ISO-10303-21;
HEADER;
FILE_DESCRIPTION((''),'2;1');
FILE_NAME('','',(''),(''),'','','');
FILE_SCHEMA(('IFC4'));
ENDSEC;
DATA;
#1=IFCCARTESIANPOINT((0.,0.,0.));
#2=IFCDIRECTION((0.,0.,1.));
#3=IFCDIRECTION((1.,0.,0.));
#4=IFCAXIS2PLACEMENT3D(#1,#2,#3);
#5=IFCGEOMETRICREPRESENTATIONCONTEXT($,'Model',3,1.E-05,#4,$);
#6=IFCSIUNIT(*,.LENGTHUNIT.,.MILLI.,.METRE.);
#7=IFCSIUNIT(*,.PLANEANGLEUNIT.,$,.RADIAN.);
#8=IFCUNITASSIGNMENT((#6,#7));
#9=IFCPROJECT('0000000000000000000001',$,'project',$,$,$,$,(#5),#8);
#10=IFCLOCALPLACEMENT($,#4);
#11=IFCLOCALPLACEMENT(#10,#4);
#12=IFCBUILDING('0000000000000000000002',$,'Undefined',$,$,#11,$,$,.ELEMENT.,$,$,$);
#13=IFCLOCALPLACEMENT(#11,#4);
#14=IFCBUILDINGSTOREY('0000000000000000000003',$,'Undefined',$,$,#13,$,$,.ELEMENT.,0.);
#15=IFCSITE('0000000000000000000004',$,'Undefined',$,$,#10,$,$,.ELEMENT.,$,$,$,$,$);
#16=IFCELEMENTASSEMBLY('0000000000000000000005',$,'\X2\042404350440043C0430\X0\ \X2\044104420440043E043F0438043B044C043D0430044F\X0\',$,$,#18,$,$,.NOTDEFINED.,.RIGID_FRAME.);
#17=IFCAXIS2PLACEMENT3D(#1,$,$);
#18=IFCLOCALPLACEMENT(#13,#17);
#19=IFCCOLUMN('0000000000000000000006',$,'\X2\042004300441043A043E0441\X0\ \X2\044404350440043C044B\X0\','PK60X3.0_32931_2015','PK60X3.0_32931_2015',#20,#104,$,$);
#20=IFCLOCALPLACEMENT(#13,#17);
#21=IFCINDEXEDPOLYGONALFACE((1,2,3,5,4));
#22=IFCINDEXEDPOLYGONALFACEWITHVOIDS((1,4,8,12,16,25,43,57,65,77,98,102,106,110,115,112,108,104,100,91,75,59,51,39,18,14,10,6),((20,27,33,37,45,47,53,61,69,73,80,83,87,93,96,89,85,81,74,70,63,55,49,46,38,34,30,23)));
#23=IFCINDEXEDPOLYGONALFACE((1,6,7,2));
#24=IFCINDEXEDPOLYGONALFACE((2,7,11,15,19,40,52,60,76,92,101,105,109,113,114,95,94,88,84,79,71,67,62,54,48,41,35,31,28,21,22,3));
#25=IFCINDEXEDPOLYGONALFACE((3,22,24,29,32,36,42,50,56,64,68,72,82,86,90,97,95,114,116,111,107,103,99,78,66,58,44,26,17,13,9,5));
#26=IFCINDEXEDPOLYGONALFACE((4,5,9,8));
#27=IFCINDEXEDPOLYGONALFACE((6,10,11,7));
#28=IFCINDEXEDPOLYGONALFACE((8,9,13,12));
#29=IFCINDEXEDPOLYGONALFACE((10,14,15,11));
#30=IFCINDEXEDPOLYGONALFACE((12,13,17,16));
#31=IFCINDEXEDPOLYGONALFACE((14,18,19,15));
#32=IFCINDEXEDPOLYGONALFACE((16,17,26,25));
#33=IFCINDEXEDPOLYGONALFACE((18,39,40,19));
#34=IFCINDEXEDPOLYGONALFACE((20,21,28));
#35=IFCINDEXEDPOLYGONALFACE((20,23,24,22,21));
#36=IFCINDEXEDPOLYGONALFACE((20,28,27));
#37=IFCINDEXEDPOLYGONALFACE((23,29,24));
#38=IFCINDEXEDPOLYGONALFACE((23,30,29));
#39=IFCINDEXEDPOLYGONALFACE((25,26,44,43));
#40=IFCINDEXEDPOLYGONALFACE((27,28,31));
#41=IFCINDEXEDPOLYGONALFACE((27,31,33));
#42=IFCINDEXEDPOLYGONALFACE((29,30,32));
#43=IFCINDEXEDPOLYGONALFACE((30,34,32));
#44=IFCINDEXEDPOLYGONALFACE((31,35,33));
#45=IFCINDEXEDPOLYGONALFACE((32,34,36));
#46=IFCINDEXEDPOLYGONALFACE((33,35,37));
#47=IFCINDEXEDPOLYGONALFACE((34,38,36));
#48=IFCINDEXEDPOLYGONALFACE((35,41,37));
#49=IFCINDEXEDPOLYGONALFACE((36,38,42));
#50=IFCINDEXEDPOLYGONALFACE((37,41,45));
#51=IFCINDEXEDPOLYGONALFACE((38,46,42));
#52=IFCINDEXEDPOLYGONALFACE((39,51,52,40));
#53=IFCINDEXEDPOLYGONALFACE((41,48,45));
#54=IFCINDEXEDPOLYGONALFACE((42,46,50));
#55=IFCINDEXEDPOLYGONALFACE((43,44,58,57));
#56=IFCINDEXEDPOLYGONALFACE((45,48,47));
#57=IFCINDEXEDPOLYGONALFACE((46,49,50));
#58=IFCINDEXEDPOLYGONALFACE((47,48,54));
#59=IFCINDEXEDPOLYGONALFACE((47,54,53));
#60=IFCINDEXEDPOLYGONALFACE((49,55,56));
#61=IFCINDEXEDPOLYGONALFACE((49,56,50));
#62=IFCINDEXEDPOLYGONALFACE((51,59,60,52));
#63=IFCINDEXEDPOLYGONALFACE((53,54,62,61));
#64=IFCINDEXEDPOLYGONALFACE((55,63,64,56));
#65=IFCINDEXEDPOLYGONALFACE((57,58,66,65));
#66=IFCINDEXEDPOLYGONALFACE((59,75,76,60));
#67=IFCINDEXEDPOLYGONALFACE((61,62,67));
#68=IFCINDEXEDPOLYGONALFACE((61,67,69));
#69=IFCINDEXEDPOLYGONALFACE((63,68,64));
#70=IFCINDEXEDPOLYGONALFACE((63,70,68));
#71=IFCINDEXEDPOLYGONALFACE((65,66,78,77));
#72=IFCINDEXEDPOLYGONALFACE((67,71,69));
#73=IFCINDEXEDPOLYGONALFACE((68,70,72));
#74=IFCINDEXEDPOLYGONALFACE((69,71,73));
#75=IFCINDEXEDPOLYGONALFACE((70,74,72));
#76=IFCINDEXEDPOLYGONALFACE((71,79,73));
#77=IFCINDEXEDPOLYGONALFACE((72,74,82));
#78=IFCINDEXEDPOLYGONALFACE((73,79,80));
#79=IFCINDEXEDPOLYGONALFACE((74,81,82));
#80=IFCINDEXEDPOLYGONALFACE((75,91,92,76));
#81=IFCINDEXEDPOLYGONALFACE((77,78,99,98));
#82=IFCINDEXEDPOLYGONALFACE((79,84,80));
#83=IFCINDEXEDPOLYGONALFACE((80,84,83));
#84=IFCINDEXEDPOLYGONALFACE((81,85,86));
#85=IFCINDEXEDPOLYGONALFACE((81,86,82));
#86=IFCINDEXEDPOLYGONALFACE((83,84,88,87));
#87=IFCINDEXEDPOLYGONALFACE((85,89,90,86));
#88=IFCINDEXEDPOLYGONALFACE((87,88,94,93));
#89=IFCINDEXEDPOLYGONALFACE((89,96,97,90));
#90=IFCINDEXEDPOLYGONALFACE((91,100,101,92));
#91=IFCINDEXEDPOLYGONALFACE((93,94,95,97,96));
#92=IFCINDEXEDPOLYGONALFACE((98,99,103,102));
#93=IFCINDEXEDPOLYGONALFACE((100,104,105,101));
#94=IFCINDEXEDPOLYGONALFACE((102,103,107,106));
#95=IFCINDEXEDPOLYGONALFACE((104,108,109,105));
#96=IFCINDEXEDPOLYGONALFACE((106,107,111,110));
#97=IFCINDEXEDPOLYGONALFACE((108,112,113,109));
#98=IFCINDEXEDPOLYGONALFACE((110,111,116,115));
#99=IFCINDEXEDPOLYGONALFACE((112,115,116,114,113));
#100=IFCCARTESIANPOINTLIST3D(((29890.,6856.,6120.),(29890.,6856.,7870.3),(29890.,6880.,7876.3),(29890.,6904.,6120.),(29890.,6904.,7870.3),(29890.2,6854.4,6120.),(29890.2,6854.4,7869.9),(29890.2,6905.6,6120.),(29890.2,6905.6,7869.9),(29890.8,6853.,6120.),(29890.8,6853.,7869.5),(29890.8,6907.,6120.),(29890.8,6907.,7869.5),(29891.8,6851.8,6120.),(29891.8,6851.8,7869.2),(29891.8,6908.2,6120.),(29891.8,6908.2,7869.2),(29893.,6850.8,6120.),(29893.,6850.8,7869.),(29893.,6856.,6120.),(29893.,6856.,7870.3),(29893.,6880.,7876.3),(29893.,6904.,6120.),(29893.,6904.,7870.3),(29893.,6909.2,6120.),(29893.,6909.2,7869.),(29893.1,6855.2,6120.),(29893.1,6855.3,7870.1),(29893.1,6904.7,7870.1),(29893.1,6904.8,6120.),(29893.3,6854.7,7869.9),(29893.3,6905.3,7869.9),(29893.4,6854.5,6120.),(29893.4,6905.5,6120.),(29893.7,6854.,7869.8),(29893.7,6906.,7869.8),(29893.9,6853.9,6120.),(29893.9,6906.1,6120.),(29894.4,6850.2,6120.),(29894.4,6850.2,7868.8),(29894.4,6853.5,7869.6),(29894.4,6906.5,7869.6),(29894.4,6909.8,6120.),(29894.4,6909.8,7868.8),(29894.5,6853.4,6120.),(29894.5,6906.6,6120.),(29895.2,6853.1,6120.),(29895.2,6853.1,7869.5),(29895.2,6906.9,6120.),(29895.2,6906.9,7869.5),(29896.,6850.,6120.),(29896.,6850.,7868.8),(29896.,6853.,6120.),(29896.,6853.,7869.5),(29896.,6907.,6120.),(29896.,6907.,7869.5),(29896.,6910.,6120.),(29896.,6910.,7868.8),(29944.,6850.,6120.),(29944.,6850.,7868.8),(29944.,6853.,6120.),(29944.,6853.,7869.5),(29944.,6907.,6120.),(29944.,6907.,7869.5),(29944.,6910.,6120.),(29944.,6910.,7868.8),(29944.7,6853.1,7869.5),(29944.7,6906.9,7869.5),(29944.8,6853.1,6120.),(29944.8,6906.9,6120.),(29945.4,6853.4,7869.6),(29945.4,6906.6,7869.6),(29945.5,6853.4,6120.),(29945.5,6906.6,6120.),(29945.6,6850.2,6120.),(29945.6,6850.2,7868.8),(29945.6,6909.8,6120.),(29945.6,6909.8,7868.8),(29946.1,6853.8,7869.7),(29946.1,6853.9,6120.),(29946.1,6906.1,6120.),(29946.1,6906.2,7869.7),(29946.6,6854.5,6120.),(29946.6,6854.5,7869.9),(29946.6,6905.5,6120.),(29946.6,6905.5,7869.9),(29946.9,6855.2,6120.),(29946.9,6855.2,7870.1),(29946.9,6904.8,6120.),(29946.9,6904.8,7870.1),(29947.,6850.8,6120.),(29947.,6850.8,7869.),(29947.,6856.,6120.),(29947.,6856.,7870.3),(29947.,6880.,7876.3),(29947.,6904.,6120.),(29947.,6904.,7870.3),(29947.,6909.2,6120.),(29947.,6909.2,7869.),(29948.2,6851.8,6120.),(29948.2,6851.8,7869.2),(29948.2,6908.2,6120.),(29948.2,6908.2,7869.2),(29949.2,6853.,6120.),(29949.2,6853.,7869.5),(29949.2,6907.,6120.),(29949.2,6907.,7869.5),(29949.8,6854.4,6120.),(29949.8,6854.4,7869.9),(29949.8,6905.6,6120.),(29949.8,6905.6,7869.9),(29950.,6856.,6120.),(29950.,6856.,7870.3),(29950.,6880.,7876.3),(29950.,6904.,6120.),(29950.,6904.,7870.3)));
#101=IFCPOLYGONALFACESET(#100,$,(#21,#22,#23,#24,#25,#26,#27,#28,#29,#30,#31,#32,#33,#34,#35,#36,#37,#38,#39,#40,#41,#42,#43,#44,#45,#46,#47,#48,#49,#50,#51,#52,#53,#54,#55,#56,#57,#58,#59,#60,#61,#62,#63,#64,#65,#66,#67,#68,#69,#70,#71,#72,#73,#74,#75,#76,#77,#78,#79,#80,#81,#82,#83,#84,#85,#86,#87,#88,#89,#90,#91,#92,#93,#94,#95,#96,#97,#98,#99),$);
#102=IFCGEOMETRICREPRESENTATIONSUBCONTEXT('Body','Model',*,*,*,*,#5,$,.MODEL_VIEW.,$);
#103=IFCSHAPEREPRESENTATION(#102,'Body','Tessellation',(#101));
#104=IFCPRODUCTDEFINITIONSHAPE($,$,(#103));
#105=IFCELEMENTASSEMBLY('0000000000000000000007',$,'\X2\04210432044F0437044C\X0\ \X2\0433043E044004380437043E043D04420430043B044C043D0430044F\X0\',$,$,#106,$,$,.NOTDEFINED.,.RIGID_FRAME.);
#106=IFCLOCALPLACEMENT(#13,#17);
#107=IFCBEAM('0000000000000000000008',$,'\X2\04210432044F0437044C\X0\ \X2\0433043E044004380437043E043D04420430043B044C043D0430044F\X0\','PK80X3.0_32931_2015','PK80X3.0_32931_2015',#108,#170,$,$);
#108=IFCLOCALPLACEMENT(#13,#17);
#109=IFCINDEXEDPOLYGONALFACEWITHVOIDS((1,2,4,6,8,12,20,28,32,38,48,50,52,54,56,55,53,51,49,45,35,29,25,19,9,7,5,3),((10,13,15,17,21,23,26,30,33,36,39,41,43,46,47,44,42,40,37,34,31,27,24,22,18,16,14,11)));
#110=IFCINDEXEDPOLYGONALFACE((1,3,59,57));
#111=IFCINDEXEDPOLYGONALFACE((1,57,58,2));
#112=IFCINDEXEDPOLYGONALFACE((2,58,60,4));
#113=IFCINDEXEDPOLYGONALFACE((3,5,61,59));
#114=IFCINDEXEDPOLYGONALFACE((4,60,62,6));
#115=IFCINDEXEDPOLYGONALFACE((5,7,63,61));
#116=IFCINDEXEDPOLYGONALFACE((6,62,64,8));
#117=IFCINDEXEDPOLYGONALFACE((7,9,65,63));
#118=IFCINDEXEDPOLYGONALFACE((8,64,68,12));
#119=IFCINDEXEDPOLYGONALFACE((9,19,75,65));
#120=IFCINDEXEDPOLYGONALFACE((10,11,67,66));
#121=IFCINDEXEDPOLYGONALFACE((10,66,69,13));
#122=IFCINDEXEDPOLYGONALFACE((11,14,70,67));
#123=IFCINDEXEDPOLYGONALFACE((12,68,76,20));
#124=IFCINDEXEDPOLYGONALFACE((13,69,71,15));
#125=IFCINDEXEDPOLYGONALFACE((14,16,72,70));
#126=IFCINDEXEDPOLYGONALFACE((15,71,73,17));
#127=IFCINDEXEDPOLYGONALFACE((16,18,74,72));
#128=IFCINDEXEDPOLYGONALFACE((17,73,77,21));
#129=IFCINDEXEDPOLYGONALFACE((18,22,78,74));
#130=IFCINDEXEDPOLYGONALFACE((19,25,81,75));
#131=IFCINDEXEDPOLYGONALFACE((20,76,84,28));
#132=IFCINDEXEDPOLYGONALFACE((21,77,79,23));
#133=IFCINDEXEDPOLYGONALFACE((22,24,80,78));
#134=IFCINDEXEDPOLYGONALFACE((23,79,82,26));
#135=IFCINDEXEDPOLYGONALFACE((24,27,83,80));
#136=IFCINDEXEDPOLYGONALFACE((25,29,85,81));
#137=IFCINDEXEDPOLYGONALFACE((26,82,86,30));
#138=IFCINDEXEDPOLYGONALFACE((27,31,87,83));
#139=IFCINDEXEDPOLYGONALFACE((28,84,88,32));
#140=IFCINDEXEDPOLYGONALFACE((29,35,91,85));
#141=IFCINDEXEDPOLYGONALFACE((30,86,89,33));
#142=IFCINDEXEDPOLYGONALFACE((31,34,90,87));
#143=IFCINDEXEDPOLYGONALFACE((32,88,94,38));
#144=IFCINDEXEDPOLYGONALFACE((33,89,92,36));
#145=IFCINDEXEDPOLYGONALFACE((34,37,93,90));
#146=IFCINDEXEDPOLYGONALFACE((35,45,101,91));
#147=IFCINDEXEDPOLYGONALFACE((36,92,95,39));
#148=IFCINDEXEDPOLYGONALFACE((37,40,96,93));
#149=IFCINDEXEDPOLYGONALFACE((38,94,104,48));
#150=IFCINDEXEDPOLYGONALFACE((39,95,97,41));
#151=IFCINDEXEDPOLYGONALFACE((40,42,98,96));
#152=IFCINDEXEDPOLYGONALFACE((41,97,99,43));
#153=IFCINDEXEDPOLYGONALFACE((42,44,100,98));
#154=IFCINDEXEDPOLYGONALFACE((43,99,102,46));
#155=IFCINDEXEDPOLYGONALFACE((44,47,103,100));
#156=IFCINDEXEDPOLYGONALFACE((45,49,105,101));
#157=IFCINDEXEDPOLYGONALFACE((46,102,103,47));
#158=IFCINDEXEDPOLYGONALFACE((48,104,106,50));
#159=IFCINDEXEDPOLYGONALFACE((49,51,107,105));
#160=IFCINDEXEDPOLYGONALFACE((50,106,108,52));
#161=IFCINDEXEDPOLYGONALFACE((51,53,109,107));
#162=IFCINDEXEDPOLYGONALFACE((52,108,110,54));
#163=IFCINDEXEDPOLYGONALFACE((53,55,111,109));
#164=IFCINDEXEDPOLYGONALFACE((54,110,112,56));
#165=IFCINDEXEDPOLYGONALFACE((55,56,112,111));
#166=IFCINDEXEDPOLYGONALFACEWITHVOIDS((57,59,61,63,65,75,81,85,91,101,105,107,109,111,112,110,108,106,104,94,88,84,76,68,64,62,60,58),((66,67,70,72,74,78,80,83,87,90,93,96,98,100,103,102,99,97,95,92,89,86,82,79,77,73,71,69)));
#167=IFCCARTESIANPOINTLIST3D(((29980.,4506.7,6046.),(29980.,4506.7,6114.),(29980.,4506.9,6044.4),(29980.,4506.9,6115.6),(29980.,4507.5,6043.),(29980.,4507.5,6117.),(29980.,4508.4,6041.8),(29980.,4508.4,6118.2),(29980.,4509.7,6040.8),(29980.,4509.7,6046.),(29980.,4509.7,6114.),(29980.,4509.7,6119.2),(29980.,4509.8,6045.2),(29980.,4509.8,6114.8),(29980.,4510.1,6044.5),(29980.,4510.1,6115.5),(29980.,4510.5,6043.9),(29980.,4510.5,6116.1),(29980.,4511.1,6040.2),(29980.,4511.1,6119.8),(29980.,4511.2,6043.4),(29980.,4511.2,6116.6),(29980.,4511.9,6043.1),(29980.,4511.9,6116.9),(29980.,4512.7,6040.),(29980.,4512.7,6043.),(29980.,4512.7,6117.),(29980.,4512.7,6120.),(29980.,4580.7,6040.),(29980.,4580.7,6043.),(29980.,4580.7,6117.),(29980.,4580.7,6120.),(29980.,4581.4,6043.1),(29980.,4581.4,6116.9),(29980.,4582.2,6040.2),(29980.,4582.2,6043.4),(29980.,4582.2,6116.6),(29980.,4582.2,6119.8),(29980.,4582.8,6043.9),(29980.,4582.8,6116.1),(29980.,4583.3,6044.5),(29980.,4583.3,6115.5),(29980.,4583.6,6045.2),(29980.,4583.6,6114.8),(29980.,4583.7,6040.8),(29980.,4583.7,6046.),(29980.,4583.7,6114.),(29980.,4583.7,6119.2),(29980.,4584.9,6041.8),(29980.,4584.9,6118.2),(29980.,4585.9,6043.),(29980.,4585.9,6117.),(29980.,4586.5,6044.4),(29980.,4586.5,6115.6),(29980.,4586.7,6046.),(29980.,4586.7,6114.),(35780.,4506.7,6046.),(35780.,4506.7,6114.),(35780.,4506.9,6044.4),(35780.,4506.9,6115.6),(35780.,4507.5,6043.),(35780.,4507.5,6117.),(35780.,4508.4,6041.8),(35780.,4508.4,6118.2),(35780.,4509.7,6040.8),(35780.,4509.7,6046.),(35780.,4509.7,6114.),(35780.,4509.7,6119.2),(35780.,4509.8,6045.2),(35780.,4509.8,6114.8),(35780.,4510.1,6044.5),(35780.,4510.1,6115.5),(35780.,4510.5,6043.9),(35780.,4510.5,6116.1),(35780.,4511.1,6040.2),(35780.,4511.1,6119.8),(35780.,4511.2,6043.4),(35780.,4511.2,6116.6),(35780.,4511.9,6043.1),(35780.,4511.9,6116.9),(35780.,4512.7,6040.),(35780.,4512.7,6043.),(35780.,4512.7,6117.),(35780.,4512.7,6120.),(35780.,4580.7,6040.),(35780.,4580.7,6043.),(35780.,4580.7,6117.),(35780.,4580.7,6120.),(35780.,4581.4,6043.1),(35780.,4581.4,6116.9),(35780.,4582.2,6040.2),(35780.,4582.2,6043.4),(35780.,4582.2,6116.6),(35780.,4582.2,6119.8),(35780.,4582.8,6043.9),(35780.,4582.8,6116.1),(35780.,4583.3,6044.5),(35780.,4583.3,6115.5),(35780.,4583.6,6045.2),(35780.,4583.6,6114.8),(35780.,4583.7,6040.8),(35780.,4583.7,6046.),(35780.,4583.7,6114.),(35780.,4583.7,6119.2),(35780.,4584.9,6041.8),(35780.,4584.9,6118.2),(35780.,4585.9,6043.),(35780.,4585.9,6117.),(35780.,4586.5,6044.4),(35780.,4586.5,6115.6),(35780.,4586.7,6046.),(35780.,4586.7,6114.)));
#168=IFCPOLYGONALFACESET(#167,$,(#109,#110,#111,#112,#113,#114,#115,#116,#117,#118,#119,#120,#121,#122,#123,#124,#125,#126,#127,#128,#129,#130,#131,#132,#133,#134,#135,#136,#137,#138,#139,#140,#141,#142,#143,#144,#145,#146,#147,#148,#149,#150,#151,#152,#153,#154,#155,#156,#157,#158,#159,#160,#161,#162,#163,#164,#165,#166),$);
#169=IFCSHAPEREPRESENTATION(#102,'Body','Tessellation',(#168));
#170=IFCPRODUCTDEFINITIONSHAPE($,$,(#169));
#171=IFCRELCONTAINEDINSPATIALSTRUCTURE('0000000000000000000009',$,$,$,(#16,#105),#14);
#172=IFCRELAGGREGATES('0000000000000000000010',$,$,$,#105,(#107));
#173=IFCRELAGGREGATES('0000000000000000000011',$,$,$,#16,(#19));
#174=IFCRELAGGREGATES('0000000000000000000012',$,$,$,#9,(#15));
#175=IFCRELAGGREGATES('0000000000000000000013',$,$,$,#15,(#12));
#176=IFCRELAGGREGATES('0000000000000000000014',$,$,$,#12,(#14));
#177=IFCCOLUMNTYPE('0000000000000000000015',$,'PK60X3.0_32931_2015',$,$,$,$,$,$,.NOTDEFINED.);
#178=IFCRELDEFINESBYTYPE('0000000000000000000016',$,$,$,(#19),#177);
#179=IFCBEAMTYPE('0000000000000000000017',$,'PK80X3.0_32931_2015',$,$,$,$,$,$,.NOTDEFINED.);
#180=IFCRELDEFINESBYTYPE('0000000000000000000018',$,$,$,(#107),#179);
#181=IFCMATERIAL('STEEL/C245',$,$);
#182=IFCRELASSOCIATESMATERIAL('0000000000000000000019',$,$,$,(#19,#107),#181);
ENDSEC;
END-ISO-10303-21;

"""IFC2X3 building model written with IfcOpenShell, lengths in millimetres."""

from ifc_helpers import new_model, si_unit, frame, origin_with_axes, origin_2d_with_axis, place, context, subcontext, project, spatial, hollow_rectangle, extrude, clip, halfspace, material, type_object, element, aggregate, save


model = new_model("IFC2X3")

# Units and contexts
model_context = context("Model", 3, precision=1e-05, world=origin_with_axes())
body_context = subcontext(model_context, "Body", "Model", "MODEL_VIEW")
ifc_project = project(units=[si_unit("LENGTHUNIT", "METRE", prefix="MILLI"), si_unit("PLANEANGLEUNIT", "RADIAN")], contexts=[model_context])

# Site, building, storey
site_placement = place(None, origin_with_axes())
site = spatial("IfcSite", under=ifc_project, at=site_placement, Name="Undefined", CompositionType="ELEMENT")
building_placement = place(site_placement, origin_with_axes())
building = spatial("IfcBuilding", under=site, at=building_placement, Name="Undefined", CompositionType="ELEMENT")
storey_placement = place(building_placement, origin_with_axes())
storey = spatial("IfcBuildingStorey", under=building, at=storey_placement, Name="Undefined", CompositionType="ELEMENT", Elevation=0.0)

# Shared definitions
ifc_material = material(Name="STEEL/C245")

# Element assembly, column
column_type_1 = type_object("IfcColumnType", Name="PK60X3.0_32931_2015", PredefinedType="NOTDEFINED")
assembly_1_placement = place(storey_placement, origin_with_axes())
assembly_1 = element("IfcElementAssembly", 1, at=assembly_1_placement, inside=storey, Name="Ферма стропильная", AssemblyPlace="NOTDEFINED", PredefinedType="RIGID_FRAME")
column_1_placement = place(assembly_1_placement, frame((29920.0, 6880.0, 6120.0), z_axis=(0.0, 0.0, 1.0), x_axis=(-1.0, 0.0, 0.0)))
column_1 = element("IfcColumn", 2, at=column_1_placement, type_object=column_type_1, material=ifc_material, Name="Раскос фермы", Description="PK60X3.0_32931_2015", ObjectType="PK60X3.0_32931_2015", context=body_context, shape_type="Clipping", body=[
    clip(clip(extrude(hollow_rectangle(XDim=60.0, YDim=60.0, WallThickness=3.0, InnerFilletRadius=3.0, OuterFilletRadius=6.0, at=origin_2d_with_axis()), frame((0.0, 0.0, 1756.3), z_axis=(0.0, 0.0, -1.0), x_axis=(0.0, 1.0, 0.0)), (0.0, 0.0, 1.0), 1756.3), halfspace(frame((-30.0, 30.0, 1763.8), z_axis=(0.0, -0.243188, 0.969979), x_axis=(1.0, 0.0, 0.0)), False)), halfspace(frame((0.0, 4455.7, 639.2), z_axis=(0.0, -0.243188, -0.969979), x_axis=(-1.0, 0.0, 0.0)), True)),
])

# Element assembly, beam
beam_type_1 = type_object("IfcBeamType", Name="PK80X3.0_32931_2015", PredefinedType="NOTDEFINED")
assembly_2_placement = place(storey_placement, origin_with_axes())
assembly_2 = element("IfcElementAssembly", 3, at=assembly_2_placement, inside=storey, Name="Связь горизонтальная", AssemblyPlace="NOTDEFINED", PredefinedType="RIGID_FRAME")
beam_1_placement = place(assembly_2_placement, frame((29980.0, 4546.7, 6080.0), z_axis=(0.0, 0.0, 1.0), x_axis=(1.0, 0.0, 0.0)))
beam_1 = element("IfcBeam", 4, at=beam_1_placement, type_object=beam_type_1, material=ifc_material, Name="Связь горизонтальная", Description="PK80X3.0_32931_2015", ObjectType="PK80X3.0_32931_2015", context=body_context, shape_type="SweptSolid", body=[
    extrude(hollow_rectangle(XDim=80.0, YDim=80.0, WallThickness=3.0, InnerFilletRadius=3.0, OuterFilletRadius=6.0, at=origin_2d_with_axis()), frame((5800.0, 0.0, 0.0), z_axis=(-1.0, 0.0, 0.0), x_axis=(0.0, -1.0, 0.0)), (0.0, 0.0, 1.0), 5800.0),
])
aggregate(assembly_2, [beam_1])

aggregate(assembly_1, [column_1])

save(model, "model.ifc")
